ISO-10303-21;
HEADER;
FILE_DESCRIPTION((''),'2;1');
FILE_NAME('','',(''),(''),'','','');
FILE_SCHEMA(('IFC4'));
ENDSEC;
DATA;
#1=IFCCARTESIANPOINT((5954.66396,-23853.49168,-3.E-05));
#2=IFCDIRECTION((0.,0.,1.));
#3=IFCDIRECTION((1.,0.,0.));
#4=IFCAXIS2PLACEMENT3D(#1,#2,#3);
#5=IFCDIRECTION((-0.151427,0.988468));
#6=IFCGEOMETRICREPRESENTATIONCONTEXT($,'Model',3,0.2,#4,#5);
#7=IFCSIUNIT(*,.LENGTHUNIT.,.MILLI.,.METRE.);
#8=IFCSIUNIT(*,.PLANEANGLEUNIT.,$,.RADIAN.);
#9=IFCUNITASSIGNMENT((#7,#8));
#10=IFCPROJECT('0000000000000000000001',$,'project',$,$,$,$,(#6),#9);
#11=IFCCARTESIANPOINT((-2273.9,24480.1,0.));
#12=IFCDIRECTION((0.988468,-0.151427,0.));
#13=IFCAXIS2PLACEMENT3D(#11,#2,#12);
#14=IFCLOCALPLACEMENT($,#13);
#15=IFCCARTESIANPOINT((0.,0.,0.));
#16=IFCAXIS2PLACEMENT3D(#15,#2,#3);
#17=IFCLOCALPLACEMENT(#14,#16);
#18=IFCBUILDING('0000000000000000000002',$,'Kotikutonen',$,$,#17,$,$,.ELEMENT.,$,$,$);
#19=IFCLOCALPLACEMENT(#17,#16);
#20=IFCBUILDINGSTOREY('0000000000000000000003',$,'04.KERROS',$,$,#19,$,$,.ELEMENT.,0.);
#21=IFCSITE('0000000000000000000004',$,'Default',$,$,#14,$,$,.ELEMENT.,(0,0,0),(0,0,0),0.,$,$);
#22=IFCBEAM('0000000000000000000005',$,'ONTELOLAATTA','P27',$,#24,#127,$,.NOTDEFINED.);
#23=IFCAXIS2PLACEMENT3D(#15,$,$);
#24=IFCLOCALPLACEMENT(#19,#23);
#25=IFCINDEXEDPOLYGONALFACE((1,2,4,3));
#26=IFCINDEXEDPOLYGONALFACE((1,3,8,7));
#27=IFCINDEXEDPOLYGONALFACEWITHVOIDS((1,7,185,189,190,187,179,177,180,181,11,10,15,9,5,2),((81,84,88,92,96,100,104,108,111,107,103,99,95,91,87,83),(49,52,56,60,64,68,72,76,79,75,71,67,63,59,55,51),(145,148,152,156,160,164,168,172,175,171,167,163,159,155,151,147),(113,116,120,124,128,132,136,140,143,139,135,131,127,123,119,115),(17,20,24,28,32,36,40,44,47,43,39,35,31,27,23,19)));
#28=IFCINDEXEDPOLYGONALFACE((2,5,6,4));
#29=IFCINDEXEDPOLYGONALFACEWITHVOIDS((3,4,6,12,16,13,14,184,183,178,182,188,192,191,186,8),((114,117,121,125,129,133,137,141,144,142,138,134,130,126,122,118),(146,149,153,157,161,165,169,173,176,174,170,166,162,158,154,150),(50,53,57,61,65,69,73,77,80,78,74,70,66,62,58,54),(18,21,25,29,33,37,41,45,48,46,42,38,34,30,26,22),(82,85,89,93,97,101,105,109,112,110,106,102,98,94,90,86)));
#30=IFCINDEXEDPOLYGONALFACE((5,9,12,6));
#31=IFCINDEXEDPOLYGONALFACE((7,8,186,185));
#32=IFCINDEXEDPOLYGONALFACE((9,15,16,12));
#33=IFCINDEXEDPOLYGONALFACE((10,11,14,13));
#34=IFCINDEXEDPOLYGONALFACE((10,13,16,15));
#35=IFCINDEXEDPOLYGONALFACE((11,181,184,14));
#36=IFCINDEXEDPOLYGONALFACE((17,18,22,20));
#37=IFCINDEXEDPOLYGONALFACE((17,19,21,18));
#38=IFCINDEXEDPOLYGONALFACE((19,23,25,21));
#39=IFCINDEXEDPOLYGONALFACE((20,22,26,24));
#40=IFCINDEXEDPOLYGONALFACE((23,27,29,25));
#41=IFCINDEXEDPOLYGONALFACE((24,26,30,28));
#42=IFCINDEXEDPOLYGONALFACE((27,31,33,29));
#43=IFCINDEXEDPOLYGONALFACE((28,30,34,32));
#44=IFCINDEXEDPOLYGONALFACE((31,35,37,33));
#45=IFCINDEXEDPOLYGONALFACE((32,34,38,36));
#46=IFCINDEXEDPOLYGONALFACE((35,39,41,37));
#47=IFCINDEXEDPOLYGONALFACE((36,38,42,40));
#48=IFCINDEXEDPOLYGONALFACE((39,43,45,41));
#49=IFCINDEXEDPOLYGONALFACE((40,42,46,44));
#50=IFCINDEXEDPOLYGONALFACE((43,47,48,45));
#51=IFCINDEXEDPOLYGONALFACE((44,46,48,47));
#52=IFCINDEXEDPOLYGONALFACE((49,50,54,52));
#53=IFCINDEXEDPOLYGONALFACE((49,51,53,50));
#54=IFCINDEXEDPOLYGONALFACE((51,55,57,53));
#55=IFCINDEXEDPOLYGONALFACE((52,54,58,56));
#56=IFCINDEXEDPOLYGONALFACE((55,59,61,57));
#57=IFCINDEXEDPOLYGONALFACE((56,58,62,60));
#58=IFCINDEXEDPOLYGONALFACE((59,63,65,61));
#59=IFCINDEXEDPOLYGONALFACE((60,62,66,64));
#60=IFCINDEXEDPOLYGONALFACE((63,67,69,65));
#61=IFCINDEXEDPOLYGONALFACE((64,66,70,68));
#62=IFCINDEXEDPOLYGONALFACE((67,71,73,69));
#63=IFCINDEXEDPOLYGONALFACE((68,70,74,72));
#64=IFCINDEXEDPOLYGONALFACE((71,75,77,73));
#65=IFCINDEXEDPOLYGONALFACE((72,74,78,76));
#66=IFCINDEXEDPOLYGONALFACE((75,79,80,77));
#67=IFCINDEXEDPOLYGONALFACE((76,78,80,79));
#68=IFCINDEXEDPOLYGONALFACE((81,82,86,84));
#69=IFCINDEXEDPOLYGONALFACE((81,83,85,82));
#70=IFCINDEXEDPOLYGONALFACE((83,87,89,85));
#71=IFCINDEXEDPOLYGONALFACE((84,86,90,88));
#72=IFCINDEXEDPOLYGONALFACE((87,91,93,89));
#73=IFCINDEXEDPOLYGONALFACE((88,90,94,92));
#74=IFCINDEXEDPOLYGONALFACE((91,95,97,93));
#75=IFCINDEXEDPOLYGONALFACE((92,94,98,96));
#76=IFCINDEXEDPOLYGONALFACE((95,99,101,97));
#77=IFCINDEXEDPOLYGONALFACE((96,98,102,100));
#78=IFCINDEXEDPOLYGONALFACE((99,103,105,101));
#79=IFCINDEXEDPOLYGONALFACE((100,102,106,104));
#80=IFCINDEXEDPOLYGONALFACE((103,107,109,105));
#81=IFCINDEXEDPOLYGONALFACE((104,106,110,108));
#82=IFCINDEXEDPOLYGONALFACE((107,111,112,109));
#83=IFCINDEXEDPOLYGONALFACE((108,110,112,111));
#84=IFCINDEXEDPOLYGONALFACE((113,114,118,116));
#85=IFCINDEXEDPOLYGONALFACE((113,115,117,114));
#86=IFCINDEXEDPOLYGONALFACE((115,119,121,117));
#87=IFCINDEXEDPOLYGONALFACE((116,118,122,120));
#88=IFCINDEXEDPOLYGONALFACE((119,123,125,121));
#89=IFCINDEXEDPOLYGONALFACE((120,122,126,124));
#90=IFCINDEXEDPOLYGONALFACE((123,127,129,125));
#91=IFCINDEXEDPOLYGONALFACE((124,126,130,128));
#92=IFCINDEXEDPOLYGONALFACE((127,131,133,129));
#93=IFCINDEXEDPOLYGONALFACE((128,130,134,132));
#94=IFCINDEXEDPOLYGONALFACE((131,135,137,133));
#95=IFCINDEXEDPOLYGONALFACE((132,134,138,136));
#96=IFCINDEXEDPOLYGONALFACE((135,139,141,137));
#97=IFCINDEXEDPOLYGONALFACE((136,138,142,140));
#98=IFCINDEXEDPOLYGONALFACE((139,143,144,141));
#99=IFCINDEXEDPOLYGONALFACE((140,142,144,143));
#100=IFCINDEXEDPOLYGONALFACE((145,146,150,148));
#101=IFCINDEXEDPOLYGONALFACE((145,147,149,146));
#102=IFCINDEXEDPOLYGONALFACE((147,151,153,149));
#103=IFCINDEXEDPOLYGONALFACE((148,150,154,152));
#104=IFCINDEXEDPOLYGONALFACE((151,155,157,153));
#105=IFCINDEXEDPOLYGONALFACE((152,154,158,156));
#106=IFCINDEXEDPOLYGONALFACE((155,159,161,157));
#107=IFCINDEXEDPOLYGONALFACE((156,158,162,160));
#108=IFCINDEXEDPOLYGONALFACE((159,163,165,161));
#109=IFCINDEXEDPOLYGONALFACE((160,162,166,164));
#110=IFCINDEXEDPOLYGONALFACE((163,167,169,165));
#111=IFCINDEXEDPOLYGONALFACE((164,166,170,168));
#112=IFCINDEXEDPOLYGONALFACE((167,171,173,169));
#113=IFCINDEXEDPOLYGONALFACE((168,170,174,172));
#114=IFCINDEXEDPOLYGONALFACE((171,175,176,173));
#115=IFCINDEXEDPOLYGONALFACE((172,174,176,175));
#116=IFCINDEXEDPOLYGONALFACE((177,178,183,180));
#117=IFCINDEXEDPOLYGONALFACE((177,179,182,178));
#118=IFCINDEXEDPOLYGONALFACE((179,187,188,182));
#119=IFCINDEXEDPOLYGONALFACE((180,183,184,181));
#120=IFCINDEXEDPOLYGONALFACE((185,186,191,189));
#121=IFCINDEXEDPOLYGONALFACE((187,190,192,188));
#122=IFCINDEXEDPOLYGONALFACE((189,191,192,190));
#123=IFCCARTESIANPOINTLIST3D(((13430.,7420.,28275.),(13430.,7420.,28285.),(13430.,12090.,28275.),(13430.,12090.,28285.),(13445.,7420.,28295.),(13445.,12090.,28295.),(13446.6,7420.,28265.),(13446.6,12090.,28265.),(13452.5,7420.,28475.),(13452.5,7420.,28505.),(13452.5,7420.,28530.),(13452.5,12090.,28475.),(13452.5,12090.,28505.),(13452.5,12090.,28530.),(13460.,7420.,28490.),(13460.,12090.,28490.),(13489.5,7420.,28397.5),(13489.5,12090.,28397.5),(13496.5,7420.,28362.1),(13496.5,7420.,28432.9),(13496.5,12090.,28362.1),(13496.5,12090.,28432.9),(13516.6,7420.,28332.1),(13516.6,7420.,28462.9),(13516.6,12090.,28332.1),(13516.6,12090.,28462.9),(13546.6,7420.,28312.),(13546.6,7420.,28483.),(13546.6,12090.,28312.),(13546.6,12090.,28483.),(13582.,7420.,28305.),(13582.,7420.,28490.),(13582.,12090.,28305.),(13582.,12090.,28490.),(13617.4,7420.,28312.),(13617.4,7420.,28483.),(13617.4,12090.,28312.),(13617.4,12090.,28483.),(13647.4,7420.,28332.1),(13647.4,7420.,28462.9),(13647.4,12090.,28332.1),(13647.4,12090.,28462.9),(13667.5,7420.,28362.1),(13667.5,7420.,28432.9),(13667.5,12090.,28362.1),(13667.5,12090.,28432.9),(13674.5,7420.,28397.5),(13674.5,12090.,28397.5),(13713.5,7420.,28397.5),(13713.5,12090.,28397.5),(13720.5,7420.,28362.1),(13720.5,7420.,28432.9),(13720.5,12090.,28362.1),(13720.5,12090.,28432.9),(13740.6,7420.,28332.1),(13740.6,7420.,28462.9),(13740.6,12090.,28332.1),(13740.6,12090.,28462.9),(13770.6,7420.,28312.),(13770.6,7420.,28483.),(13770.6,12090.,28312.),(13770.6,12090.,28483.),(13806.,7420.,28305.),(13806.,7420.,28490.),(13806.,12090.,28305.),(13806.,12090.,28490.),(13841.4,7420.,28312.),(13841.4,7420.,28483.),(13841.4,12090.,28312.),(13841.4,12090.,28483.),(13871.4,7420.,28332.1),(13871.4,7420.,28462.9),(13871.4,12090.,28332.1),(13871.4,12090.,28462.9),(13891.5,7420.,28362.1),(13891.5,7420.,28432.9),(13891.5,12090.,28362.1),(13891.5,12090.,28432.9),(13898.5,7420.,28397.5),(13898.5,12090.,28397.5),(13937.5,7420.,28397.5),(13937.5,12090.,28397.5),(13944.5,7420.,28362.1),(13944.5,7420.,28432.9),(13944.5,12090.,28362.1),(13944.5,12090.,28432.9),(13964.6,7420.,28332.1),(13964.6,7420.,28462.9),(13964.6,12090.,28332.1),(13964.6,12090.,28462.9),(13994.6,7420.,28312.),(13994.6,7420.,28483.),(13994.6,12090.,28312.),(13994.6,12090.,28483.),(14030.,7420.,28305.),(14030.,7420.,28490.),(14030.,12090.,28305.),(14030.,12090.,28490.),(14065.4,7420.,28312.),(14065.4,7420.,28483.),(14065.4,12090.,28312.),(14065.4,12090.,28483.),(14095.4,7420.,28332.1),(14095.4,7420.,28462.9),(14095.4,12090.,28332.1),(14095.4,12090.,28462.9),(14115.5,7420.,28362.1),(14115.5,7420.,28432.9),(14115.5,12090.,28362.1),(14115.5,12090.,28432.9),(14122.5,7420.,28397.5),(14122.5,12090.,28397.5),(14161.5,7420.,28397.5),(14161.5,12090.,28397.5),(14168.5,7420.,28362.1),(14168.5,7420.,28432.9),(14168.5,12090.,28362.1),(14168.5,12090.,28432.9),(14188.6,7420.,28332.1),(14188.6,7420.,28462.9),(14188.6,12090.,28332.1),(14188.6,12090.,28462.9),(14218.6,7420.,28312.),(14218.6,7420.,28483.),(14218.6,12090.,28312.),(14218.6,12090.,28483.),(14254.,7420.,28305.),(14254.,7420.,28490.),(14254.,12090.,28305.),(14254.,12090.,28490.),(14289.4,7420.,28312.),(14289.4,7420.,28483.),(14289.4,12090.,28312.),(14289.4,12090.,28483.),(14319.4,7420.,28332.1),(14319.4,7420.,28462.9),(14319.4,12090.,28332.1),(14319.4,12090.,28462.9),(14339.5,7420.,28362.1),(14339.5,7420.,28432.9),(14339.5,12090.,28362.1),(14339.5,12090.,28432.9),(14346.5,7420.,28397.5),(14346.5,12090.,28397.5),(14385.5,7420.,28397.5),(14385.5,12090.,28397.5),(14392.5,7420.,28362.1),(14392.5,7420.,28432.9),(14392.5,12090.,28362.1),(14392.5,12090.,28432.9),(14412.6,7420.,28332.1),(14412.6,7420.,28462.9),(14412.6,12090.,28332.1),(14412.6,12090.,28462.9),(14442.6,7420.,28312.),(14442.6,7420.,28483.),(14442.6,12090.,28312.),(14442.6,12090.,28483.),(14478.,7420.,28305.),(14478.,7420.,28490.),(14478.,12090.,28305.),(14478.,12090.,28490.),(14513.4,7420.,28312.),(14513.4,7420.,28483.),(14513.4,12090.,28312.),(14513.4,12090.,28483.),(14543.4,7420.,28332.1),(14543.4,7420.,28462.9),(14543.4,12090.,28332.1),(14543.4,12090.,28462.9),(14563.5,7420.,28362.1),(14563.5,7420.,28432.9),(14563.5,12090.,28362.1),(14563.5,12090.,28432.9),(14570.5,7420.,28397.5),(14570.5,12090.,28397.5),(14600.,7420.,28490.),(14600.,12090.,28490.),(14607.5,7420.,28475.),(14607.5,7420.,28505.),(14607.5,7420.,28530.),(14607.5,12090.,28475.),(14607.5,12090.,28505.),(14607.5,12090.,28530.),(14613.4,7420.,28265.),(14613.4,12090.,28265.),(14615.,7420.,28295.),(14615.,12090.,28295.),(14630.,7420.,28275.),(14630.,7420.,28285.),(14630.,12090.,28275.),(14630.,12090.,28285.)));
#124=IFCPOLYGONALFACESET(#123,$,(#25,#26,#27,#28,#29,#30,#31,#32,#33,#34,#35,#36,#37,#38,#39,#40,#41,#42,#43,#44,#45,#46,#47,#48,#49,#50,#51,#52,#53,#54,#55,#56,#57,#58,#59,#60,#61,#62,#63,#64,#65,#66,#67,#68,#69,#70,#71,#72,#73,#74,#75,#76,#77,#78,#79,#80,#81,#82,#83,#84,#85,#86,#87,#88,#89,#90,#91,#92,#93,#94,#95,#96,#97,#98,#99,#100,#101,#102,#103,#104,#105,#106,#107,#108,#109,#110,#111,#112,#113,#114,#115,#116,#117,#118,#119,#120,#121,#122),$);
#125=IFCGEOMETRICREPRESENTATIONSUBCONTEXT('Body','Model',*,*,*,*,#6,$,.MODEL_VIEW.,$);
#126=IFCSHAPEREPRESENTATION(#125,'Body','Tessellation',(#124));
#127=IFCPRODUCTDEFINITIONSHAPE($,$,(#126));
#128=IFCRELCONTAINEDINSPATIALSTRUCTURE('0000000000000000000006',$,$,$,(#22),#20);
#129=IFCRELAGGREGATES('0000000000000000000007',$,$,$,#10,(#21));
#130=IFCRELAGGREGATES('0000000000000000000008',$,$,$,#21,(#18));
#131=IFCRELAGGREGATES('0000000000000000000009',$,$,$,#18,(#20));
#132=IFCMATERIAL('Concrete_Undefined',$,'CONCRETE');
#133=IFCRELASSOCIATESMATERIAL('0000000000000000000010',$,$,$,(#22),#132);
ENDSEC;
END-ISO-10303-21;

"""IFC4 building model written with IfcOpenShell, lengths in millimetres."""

from ifc_helpers import new_model, si_unit, direction, frame, origin_with_axes, place, context, subcontext, project, spatial, line, indexed_curve, outline, extrude, material, element, save


model = new_model("IFC4")

# Units and contexts
model_context = context("Model", 3, precision=0.2, world=frame((5954.66396, -23853.49168, -3e-05), z_axis=(0.0, 0.0, 1.0), x_axis=(1.0, 0.0, 0.0)), true_north=direction((-0.151427, 0.988468)))
body_context = subcontext(model_context, "Body", "Model", "MODEL_VIEW")
ifc_project = project(units=[si_unit("LENGTHUNIT", "METRE", prefix="MILLI"), si_unit("PLANEANGLEUNIT", "RADIAN")], contexts=[model_context])

# Site, building, storey
site_placement = place(None, frame((-2273.9, 24480.1, 0.0), z_axis=(0.0, 0.0, 1.0), x_axis=(0.988468, -0.151427, 0.0)))
site = spatial("IfcSite", under=ifc_project, at=site_placement, Name="Default", CompositionType="ELEMENT", RefLatitude=(0, 0, 0), RefLongitude=(0, 0, 0), RefElevation=0.0)
building_placement = place(site_placement, origin_with_axes())
building = spatial("IfcBuilding", under=site, at=building_placement, Name="Kotikutonen", CompositionType="ELEMENT")
storey_placement = place(building_placement, origin_with_axes())
storey = spatial("IfcBuildingStorey", under=building, at=storey_placement, Name="04.KERROS", CompositionType="ELEMENT", Elevation=0.0)

# Shared definitions
ifc_material_1 = material(Name="Concrete_Undefined", Category="CONCRETE")

# Beam
beam_1_placement = place(storey_placement, frame((14030.0, 12090.0, 28397.5), z_axis=(-1.0, 0.0, 0.0), x_axis=(0.0, -1.0, 0.0)))
element("IfcBeam", 1, at=beam_1_placement, inside=storey, material=ifc_material_1, Name="ONTELOLAATTA", Description="P27", PredefinedType="NOTDEFINED", context=body_context, shape_type="SolidModel", body=[
    extrude(outline(indexed_curve([(-600.0, -122.5), (-583.4, -132.5), (583.4, -132.5), (600.0, -122.5), (600.0, -112.5), (585.0, -102.5), (577.5, 77.5), (570.0, 92.5), (577.5, 107.5), (577.5, 132.5), (-577.5, 132.5), (-577.5, 107.5), (-570.0, 92.5), (-577.5, 77.5), (-585.0, -102.5), (-600.0, -112.5)], segments=[line(1, 2, 3, 4, 5, 6, 7, 8, 9, 10, 11, 12, 13, 14, 15, 16, 1)]), holes=[indexed_curve([(-448.0, -92.5), (-483.4, -85.5), (-513.4, -65.4), (-533.5, -35.4), (-540.5, 0.0), (-533.5, 35.4), (-513.4, 65.4), (-483.4, 85.5), (-448.0, 92.5), (-412.6, 85.5), (-382.6, 65.4), (-362.5, 35.4), (-355.5, 0.0), (-362.5, -35.4), (-382.6, -65.4), (-412.6, -85.5)], segments=[line(1, 2, 3, 4, 5, 6, 7, 8, 9, 10, 11, 12, 13, 14, 15, 16, 1)]), indexed_curve([(-224.0, -92.5), (-259.4, -85.5), (-289.4, -65.4), (-309.5, -35.4), (-316.5, 0.0), (-309.5, 35.4), (-289.4, 65.4), (-259.4, 85.5), (-224.0, 92.5), (-188.6, 85.5), (-158.6, 65.4), (-138.5, 35.4), (-131.5, 0.0), (-138.5, -35.4), (-158.6, -65.4), (-188.6, -85.5)], segments=[line(1, 2, 3, 4, 5, 6, 7, 8, 9, 10, 11, 12, 13, 14, 15, 16, 1)]), indexed_curve([(0.0, -92.5), (-35.4, -85.5), (-65.4, -65.4), (-85.5, -35.4), (-92.5, 0.0), (-85.5, 35.4), (-65.4, 65.4), (-35.4, 85.5), (0.0, 92.5), (35.4, 85.5), (65.4, 65.4), (85.5, 35.4), (92.5, 0.0), (85.5, -35.4), (65.4, -65.4), (35.4, -85.5)], segments=[line(1, 2, 3, 4, 5, 6, 7, 8, 9, 10, 11, 12, 13, 14, 15, 16, 1)]), indexed_curve([(224.0, -92.5), (188.6, -85.5), (158.6, -65.4), (138.5, -35.4), (131.5, 0.0), (138.5, 35.4), (158.6, 65.4), (188.6, 85.5), (224.0, 92.5), (259.4, 85.5), (289.4, 65.4), (309.5, 35.4), (316.5, 0.0), (309.5, -35.4), (289.4, -65.4), (259.4, -85.5)], segments=[line(1, 2, 3, 4, 5, 6, 7, 8, 9, 10, 11, 12, 13, 14, 15, 16, 1)]), indexed_curve([(448.0, -92.5), (412.6, -85.5), (382.6, -65.4), (362.5, -35.4), (355.5, 0.0), (362.5, 35.4), (382.6, 65.4), (412.6, 85.5), (448.0, 92.5), (483.4, 85.5), (513.4, 65.4), (533.5, 35.4), (540.5, 0.0), (533.5, -35.4), (513.4, -65.4), (483.4, -85.5)], segments=[line(1, 2, 3, 4, 5, 6, 7, 8, 9, 10, 11, 12, 13, 14, 15, 16, 1)])]), frame((0.0, 0.0, 0.0), z_axis=(-1.0, 0.0, 0.0), x_axis=(0.0, 0.0, 1.0)), (0.0, 0.0, -1.0), 4670.0),
])

save(model, "model.ifc")
